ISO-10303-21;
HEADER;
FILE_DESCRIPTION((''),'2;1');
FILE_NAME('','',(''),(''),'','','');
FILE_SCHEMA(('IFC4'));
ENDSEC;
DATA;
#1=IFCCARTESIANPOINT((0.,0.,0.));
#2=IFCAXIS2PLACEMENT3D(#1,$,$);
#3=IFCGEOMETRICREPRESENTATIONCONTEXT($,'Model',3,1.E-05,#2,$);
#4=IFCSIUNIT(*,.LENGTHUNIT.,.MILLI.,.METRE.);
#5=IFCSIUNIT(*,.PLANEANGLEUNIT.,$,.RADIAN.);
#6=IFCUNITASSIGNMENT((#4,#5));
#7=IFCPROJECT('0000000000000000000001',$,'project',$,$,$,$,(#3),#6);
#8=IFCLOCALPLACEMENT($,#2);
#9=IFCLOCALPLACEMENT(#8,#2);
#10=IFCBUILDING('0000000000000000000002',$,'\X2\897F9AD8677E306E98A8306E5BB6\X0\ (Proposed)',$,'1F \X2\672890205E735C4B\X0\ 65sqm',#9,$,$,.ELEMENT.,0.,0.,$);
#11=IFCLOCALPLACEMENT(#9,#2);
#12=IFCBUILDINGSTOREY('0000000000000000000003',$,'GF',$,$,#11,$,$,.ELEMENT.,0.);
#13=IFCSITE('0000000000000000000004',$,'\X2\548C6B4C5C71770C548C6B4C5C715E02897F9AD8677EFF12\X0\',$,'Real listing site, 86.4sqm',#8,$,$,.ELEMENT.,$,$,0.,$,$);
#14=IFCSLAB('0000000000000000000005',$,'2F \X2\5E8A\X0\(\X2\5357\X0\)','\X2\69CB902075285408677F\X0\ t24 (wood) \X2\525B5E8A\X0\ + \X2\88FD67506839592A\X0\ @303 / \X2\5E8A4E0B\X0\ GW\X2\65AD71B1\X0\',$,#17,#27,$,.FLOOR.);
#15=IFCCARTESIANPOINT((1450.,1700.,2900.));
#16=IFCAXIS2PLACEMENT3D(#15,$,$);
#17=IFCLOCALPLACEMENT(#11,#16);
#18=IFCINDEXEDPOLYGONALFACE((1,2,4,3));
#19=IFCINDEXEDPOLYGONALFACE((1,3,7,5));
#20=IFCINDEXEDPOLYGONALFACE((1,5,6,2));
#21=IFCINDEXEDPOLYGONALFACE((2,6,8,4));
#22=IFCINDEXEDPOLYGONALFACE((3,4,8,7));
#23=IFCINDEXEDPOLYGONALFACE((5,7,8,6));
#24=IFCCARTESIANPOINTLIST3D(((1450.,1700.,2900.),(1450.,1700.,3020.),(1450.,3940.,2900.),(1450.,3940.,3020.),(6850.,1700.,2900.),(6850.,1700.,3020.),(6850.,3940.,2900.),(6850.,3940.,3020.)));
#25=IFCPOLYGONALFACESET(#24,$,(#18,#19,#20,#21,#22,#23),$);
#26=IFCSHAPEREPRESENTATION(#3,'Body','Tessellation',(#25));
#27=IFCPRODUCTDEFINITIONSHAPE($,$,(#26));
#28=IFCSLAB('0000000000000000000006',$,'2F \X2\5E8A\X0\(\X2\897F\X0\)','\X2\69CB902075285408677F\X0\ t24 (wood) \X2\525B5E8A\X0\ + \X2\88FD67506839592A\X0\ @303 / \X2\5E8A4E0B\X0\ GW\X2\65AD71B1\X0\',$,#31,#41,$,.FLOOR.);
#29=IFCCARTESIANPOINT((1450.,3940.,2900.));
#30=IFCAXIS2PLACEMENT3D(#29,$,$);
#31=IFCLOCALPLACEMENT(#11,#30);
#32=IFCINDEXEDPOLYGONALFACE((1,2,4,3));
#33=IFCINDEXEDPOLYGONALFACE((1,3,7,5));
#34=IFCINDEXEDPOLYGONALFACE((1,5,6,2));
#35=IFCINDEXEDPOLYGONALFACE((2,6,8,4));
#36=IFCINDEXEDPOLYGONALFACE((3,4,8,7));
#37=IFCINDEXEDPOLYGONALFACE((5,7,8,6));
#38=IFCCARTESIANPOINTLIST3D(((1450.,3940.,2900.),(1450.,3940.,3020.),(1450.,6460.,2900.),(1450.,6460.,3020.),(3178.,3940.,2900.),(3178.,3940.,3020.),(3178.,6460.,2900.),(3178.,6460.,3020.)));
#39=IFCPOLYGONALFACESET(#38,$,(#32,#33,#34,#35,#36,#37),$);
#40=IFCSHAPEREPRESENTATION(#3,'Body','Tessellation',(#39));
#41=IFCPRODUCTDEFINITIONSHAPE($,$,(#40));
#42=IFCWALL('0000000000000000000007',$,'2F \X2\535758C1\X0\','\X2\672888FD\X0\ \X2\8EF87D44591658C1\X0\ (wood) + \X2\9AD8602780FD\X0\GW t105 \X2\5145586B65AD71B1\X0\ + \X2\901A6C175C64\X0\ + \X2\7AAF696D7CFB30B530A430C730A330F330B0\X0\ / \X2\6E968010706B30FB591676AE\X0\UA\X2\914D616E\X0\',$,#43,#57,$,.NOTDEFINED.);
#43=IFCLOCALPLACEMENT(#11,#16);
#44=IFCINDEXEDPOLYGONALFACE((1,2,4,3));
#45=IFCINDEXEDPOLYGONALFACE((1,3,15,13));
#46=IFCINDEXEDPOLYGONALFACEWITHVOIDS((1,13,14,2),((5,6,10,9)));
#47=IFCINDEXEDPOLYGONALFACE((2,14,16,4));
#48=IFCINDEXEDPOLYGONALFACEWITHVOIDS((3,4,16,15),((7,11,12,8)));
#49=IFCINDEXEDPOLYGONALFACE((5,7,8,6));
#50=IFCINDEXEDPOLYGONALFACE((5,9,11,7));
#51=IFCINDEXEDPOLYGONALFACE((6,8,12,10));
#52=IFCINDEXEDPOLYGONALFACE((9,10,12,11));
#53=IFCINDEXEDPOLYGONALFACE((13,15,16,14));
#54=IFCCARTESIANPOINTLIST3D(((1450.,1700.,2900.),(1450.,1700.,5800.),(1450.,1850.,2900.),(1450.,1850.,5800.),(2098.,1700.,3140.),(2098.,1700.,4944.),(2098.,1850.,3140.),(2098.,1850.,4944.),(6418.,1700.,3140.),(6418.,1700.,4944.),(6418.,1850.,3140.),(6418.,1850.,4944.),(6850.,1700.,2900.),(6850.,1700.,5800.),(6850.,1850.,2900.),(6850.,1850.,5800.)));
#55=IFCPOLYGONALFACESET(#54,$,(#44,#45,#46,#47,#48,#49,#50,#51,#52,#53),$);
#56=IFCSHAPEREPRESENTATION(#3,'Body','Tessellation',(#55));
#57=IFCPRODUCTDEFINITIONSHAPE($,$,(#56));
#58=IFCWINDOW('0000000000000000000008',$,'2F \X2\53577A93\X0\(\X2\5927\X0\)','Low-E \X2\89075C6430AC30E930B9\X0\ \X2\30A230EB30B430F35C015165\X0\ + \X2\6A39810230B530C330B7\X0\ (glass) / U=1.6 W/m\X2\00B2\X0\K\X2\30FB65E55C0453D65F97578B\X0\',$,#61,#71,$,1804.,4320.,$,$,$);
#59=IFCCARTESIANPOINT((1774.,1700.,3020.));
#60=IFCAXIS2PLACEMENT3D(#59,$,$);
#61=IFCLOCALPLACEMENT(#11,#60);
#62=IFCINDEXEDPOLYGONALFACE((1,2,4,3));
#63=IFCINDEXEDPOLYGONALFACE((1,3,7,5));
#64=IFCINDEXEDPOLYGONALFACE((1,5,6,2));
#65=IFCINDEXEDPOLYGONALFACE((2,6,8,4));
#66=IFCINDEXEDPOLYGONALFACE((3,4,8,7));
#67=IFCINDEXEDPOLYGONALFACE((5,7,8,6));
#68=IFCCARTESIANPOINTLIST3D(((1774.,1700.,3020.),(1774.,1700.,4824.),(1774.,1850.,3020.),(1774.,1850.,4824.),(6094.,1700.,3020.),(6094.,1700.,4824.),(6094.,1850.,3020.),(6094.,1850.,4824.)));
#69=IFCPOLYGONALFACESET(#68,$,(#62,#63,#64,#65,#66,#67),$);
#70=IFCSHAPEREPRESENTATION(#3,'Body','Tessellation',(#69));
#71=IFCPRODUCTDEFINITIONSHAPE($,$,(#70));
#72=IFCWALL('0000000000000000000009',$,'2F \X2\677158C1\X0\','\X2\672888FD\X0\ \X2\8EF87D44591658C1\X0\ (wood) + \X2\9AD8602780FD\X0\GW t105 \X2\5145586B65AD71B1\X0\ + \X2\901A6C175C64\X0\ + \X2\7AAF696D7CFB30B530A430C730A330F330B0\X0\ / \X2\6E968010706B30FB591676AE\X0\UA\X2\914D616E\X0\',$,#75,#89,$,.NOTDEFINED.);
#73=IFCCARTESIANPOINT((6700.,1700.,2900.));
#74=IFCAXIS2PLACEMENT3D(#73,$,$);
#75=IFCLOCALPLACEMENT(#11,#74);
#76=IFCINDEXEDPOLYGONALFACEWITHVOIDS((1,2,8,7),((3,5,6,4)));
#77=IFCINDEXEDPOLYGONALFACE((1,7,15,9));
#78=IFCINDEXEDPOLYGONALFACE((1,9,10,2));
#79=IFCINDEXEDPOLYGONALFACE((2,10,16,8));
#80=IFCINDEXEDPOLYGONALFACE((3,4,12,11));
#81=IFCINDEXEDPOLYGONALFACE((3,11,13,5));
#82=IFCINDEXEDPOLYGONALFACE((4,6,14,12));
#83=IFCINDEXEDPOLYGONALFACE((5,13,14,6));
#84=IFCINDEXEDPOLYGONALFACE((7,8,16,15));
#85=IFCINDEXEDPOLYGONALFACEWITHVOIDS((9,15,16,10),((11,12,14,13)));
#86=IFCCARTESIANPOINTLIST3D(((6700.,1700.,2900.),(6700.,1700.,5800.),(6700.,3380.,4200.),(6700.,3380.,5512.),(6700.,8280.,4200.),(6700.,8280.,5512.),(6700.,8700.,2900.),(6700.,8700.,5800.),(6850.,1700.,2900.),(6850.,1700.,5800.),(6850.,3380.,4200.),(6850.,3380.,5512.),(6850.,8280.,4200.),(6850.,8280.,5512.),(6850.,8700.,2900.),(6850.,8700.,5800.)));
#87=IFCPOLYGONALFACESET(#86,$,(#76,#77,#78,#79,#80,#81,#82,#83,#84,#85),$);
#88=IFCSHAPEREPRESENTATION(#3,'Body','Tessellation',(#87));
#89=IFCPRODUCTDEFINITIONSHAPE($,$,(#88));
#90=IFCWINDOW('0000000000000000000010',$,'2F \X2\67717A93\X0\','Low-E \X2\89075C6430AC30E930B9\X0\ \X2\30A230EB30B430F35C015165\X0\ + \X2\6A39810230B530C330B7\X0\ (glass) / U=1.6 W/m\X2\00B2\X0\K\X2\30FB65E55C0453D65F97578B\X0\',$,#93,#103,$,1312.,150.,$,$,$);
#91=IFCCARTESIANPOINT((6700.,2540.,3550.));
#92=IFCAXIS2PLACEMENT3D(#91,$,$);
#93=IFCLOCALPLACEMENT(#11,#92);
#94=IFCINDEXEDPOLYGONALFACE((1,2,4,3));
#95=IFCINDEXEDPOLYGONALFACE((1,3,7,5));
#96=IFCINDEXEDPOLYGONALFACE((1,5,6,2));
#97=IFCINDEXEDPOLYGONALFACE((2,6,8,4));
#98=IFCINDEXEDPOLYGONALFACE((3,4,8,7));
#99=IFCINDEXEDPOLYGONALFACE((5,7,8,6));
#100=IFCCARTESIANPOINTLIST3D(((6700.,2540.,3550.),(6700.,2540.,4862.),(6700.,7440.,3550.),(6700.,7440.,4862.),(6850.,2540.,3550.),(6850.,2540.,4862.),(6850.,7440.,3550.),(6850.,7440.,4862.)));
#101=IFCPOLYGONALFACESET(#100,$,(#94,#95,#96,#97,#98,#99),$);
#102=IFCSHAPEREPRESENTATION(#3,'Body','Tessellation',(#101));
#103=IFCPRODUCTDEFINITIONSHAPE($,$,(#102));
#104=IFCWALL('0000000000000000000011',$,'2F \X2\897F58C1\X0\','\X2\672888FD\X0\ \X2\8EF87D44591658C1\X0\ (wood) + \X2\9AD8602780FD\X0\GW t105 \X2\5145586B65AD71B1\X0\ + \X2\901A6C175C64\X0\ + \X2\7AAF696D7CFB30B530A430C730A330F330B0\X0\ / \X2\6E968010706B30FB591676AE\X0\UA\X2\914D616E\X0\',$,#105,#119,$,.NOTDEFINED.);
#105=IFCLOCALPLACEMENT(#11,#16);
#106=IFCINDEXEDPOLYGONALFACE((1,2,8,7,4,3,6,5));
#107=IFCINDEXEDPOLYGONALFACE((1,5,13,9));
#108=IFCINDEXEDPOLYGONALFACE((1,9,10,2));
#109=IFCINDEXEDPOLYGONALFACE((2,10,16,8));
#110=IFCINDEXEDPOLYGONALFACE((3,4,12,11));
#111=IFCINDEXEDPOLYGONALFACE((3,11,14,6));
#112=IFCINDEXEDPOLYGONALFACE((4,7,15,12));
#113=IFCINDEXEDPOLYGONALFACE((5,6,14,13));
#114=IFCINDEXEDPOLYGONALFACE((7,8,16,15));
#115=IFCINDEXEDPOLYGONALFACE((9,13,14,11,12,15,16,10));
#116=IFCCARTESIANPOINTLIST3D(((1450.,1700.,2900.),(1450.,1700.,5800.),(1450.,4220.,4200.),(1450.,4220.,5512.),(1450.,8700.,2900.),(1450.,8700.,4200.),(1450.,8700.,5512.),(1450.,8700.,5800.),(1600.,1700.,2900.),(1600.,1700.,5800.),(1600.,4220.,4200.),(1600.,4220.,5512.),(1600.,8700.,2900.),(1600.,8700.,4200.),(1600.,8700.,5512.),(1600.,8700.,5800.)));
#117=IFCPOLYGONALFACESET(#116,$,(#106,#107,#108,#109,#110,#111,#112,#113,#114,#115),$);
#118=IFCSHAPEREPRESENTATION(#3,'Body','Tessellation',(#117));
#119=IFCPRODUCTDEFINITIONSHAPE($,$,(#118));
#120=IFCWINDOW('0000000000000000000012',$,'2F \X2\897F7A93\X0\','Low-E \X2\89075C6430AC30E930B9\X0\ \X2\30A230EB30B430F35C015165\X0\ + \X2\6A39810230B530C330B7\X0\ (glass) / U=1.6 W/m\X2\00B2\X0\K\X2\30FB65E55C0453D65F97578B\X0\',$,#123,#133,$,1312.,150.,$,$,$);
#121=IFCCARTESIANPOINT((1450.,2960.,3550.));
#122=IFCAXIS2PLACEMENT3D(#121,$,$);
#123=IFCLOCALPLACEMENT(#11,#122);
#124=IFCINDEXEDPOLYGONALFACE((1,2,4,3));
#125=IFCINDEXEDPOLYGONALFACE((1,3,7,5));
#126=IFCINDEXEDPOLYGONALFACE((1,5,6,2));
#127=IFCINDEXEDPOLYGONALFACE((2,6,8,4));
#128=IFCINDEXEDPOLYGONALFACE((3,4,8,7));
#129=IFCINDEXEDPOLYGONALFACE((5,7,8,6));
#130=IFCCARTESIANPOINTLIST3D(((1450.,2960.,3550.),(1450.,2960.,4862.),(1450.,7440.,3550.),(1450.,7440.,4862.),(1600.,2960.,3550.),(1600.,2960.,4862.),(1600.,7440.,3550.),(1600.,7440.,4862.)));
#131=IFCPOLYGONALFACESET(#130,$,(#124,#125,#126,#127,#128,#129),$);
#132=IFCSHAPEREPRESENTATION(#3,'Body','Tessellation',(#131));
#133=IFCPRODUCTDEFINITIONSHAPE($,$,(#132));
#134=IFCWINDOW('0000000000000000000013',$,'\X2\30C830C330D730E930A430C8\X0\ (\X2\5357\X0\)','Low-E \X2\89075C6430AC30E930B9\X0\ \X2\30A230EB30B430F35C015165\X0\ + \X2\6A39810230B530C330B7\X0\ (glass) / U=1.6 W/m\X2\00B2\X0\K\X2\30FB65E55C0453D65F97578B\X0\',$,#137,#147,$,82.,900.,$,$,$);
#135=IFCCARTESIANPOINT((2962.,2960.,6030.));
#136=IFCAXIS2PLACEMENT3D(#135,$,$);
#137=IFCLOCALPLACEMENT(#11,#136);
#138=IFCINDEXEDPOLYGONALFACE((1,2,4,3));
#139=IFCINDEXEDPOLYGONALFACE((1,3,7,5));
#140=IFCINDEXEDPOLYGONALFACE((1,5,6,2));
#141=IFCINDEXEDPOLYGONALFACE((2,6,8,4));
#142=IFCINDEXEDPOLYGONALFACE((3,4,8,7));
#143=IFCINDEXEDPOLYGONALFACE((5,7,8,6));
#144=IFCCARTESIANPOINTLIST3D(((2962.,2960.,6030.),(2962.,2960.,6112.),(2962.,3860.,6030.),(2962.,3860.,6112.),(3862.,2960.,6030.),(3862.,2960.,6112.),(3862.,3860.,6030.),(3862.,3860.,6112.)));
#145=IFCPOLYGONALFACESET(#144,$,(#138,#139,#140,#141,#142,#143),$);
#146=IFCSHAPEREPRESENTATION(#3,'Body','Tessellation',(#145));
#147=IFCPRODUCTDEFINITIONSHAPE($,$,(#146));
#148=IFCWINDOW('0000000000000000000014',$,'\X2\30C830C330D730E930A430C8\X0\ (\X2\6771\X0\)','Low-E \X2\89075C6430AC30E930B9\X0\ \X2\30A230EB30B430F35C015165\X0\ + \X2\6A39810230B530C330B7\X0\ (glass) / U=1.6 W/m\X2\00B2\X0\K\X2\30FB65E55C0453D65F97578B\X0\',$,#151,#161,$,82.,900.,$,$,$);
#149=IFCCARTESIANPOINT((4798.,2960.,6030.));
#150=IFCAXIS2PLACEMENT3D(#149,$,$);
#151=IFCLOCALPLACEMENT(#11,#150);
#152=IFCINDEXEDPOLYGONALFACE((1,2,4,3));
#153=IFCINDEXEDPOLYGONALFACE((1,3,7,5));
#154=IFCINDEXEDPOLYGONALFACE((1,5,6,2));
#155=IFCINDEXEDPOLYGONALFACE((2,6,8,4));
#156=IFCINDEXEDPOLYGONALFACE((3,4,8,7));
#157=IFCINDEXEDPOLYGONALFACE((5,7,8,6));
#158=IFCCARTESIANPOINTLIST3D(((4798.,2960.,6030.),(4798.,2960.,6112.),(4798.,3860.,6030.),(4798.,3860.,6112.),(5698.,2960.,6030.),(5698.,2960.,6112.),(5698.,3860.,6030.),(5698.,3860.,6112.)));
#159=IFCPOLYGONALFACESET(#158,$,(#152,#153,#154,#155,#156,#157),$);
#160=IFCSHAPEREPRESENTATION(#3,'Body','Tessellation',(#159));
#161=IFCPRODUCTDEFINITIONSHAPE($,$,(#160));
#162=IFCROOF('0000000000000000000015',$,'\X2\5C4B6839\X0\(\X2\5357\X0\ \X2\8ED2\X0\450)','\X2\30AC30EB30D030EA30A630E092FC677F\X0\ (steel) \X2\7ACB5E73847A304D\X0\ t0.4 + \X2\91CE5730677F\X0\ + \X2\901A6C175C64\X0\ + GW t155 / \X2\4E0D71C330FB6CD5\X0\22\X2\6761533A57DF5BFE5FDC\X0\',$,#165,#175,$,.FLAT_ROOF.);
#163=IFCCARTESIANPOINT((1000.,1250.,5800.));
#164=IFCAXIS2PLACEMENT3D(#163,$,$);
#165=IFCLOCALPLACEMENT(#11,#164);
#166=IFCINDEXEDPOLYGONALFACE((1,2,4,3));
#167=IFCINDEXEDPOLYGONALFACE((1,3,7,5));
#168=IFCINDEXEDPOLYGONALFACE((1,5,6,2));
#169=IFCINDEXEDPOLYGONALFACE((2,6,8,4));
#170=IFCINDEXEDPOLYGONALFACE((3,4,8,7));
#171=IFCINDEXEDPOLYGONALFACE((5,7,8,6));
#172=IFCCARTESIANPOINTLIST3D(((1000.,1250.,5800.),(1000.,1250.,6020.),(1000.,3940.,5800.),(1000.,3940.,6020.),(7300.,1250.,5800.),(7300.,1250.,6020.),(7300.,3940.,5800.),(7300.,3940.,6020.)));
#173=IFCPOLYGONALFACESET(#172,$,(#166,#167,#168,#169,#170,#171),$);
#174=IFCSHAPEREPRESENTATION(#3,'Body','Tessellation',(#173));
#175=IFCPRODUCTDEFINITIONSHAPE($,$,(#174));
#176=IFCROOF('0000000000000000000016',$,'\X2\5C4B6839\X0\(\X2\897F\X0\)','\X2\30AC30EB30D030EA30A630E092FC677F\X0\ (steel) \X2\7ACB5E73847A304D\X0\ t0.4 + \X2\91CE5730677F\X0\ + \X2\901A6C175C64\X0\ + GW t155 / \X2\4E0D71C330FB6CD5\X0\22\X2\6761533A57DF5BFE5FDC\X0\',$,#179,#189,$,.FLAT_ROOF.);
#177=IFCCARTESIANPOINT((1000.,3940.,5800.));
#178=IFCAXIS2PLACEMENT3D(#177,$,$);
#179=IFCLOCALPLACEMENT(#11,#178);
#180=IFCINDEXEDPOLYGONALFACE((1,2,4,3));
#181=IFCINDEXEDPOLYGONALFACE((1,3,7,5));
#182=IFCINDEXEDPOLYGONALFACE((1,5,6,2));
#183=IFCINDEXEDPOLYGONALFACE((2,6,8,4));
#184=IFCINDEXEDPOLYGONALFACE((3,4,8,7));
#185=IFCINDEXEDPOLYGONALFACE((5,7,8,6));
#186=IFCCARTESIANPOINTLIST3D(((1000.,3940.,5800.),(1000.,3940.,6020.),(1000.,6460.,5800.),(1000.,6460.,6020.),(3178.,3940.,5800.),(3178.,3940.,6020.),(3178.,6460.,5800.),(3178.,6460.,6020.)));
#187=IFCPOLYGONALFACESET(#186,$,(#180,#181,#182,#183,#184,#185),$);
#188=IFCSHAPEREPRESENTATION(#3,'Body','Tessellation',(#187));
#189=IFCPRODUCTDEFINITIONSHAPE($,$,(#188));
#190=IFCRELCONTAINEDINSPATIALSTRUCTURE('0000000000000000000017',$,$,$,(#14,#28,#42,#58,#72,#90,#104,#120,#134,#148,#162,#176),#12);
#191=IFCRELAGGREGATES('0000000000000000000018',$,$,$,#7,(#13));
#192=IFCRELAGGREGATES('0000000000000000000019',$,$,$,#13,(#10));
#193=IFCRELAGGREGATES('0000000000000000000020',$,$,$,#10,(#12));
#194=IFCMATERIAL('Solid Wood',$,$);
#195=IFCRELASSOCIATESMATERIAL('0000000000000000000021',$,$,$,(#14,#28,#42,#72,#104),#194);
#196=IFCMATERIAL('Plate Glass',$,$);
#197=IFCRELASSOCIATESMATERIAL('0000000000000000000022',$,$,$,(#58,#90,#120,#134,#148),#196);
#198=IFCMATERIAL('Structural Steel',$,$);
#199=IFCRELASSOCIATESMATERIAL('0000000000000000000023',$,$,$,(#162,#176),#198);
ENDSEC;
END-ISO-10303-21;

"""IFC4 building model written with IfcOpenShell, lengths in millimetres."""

from ifc_helpers import new_model, si_unit, frame, frame_2d, origin, place, context, project, spatial, rectangle, extrude, material, element, fill, save


model = new_model("IFC4")

# Units and contexts
model_context = context("Model", 3, precision=1e-05, world=origin())
ifc_project = project(units=[si_unit("LENGTHUNIT", "METRE", prefix="MILLI"), si_unit("PLANEANGLEUNIT", "RADIAN")], contexts=[model_context])

# Site, building, storey
site_placement = place(None, origin())
site = spatial("IfcSite", under=ifc_project, at=site_placement, Name="和歌山県和歌山市西高松２", ObjectType="Real listing site, 86.4sqm", CompositionType="ELEMENT", RefElevation=0.0)
building_placement = place(site_placement, origin())
building = spatial("IfcBuilding", under=site, at=building_placement, Name="西高松の風の家 (Proposed)", ObjectType="1F 木造平屋 65sqm", CompositionType="ELEMENT", ElevationOfRefHeight=0.0, ElevationOfTerrain=0.0)
storey_placement = place(building_placement, origin())
storey = spatial("IfcBuildingStorey", under=building, at=storey_placement, Name="GF", CompositionType="ELEMENT", Elevation=0.0)

# Slabs
ifc_material_1 = material(Name="Solid Wood")
slab_1_placement = place(storey_placement, frame((1450.0, 1700.0, 2900.0)))
element("IfcSlab", 1, at=slab_1_placement, inside=storey, material=ifc_material_1, Name="2F 床(南)", Description="構造用合板 t24 (wood) 剛床 + 製材根太 @303 / 床下 GW断熱", PredefinedType="FLOOR", context=model_context, shape_type="SweptSolid", body=[
    extrude(rectangle(XDim=5400.0, YDim=2240.0, at=frame_2d((2700.0, 1120.0))), frame((1450.0, 1700.0, 2900.0)), (0.0, 0.0, 1.0), 120.0),
])
slab_2_placement = place(storey_placement, frame((1450.0, 3940.0, 2900.0)))
element("IfcSlab", 2, at=slab_2_placement, inside=storey, material=ifc_material_1, Name="2F 床(西)", Description="構造用合板 t24 (wood) 剛床 + 製材根太 @303 / 床下 GW断熱", PredefinedType="FLOOR", context=model_context, shape_type="SweptSolid", body=[
    extrude(rectangle(XDim=1728.0, YDim=2520.0, at=frame_2d((864.0, 1260.0))), frame((1450.0, 3940.0, 2900.0)), (0.0, 0.0, 1.0), 120.0),
])

# Walls, openings, windows
wall_1_placement = place(storey_placement, frame((1450.0, 1700.0, 2900.0)))
wall_1 = element("IfcWall", 3, at=wall_1_placement, inside=storey, material=ifc_material_1, Name="2F 南壁", Description="木製 軸組外壁 (wood) + 高性能GW t105 充填断熱 + 通気層 + 窯業系サイディング / 準耐火・外皮UA配慮", PredefinedType="NOTDEFINED", context=model_context, shape_type="SweptSolid", body=[
    extrude(rectangle(XDim=5400.0, YDim=150.0, at=frame_2d((2700.0, 75.0))), frame((1450.0, 1700.0, 2900.0)), (0.0, 0.0, 1.0), 2900.0),
])
opening_1_placement = place(storey_placement, frame((1774.0, 1700.0, 3020.0)))
opening_1 = element("IfcOpeningElement", 4, at=opening_1_placement, cuts=wall_1, PredefinedType="NOTDEFINED", context=model_context, shape_type="SweptSolid", body=[
    extrude(rectangle(XDim=4320.0, YDim=150.0, at=frame_2d((2160.0, 75.0))), frame((1774.0, 1700.0, 3020.0)), (0.0, 0.0, 1.0), 1804.0),
])
ifc_material_2 = material(Name="Plate Glass")
window_1_placement = place(storey_placement, frame((1774.0, 1700.0, 3020.0)))
window_1 = element("IfcWindow", 5, at=window_1_placement, inside=storey, material=ifc_material_2, Name="2F 南窓(大)", Description="Low-E 複層ガラス アルゴン封入 + 樹脂サッシ (glass) / U=1.6 W/m²K・日射取得型", OverallHeight=1804.0, OverallWidth=4320.0, context=model_context, shape_type="SweptSolid", body=[
    extrude(rectangle(XDim=4320.0, YDim=150.0, at=frame_2d((2160.0, 75.0))), frame((1774.0, 1700.0, 3020.0)), (0.0, 0.0, 1.0), 1804.0),
])
fill(opening_1, window_1)
wall_2_placement = place(storey_placement, frame((6700.0, 1700.0, 2900.0)))
wall_2 = element("IfcWall", 6, at=wall_2_placement, inside=storey, material=ifc_material_1, Name="2F 東壁", Description="木製 軸組外壁 (wood) + 高性能GW t105 充填断熱 + 通気層 + 窯業系サイディング / 準耐火・外皮UA配慮", PredefinedType="NOTDEFINED", context=model_context, shape_type="SweptSolid", body=[
    extrude(rectangle(XDim=150.0, YDim=7000.0, at=frame_2d((75.0, 3500.0))), frame((6700.0, 1700.0, 2900.0)), (0.0, 0.0, 1.0), 2900.0),
])
opening_2_placement = place(storey_placement, frame((6700.0, 2540.0, 3550.0)))
opening_2 = element("IfcOpeningElement", 7, at=opening_2_placement, cuts=wall_2, PredefinedType="NOTDEFINED", context=model_context, shape_type="SweptSolid", body=[
    extrude(rectangle(XDim=150.0, YDim=4900.0, at=frame_2d((75.0, 2450.0))), frame((6700.0, 2540.0, 3550.0)), (0.0, 0.0, 1.0), 1312.0),
])
window_2_placement = place(storey_placement, frame((6700.0, 2540.0, 3550.0)))
window_2 = element("IfcWindow", 8, at=window_2_placement, inside=storey, material=ifc_material_2, Name="2F 東窓", Description="Low-E 複層ガラス アルゴン封入 + 樹脂サッシ (glass) / U=1.6 W/m²K・日射取得型", OverallHeight=1312.0, OverallWidth=150.0, context=model_context, shape_type="SweptSolid", body=[
    extrude(rectangle(XDim=150.0, YDim=4900.0, at=frame_2d((75.0, 2450.0))), frame((6700.0, 2540.0, 3550.0)), (0.0, 0.0, 1.0), 1312.0),
])
fill(opening_2, window_2)
wall_3_placement = place(storey_placement, frame((1450.0, 1700.0, 2900.0)))
wall_3 = element("IfcWall", 9, at=wall_3_placement, inside=storey, material=ifc_material_1, Name="2F 西壁", Description="木製 軸組外壁 (wood) + 高性能GW t105 充填断熱 + 通気層 + 窯業系サイディング / 準耐火・外皮UA配慮", PredefinedType="NOTDEFINED", context=model_context, shape_type="SweptSolid", body=[
    extrude(rectangle(XDim=150.0, YDim=7000.0, at=frame_2d((75.0, 3500.0))), frame((1450.0, 1700.0, 2900.0)), (0.0, 0.0, 1.0), 2900.0),
])
opening_3_placement = place(storey_placement, frame((1450.0, 2960.0, 3550.0)))
opening_3 = element("IfcOpeningElement", 10, at=opening_3_placement, cuts=wall_3, PredefinedType="NOTDEFINED", context=model_context, shape_type="SweptSolid", body=[
    extrude(rectangle(XDim=150.0, YDim=4480.0, at=frame_2d((75.0, 2240.0))), frame((1450.0, 2960.0, 3550.0)), (0.0, 0.0, 1.0), 1312.0),
])
window_3_placement = place(storey_placement, frame((1450.0, 2960.0, 3550.0)))
window_3 = element("IfcWindow", 11, at=window_3_placement, inside=storey, material=ifc_material_2, Name="2F 西窓", Description="Low-E 複層ガラス アルゴン封入 + 樹脂サッシ (glass) / U=1.6 W/m²K・日射取得型", OverallHeight=1312.0, OverallWidth=150.0, context=model_context, shape_type="SweptSolid", body=[
    extrude(rectangle(XDim=150.0, YDim=4480.0, at=frame_2d((75.0, 2240.0))), frame((1450.0, 2960.0, 3550.0)), (0.0, 0.0, 1.0), 1312.0),
])
fill(opening_3, window_3)

# Windows
window_4_placement = place(storey_placement, frame((2962.0, 2960.0, 6030.0)))
element("IfcWindow", 12, at=window_4_placement, inside=storey, material=ifc_material_2, Name="トップライト (南)", Description="Low-E 複層ガラス アルゴン封入 + 樹脂サッシ (glass) / U=1.6 W/m²K・日射取得型", OverallHeight=82.0, OverallWidth=900.0, context=model_context, shape_type="SweptSolid", body=[
    extrude(rectangle(XDim=900.0, YDim=900.0, at=frame_2d((450.0, 450.0))), frame((2962.0, 2960.0, 6030.0)), (0.0, 0.0, 1.0), 82.0),
])
window_5_placement = place(storey_placement, frame((4798.0, 2960.0, 6030.0)))
element("IfcWindow", 13, at=window_5_placement, inside=storey, material=ifc_material_2, Name="トップライト (東)", Description="Low-E 複層ガラス アルゴン封入 + 樹脂サッシ (glass) / U=1.6 W/m²K・日射取得型", OverallHeight=82.0, OverallWidth=900.0, context=model_context, shape_type="SweptSolid", body=[
    extrude(rectangle(XDim=900.0, YDim=900.0, at=frame_2d((450.0, 450.0))), frame((4798.0, 2960.0, 6030.0)), (0.0, 0.0, 1.0), 82.0),
])

# Roofs
ifc_material_3 = material(Name="Structural Steel")
roof_1_placement = place(storey_placement, frame((1000.0, 1250.0, 5800.0)))
element("IfcRoof", 14, at=roof_1_placement, inside=storey, material=ifc_material_3, Name="屋根(南 軒450)", Description="ガルバリウム鋼板 (steel) 立平葺き t0.4 + 野地板 + 通気層 + GW t155 / 不燃・法22条区域対応", PredefinedType="FLAT_ROOF", context=model_context, shape_type="SweptSolid", body=[
    extrude(rectangle(XDim=6300.0, YDim=2690.0, at=frame_2d((3150.0, 1345.0))), frame((1000.0, 1250.0, 5800.0)), (0.0, 0.0, 1.0), 220.0),
])
roof_2_placement = place(storey_placement, frame((1000.0, 3940.0, 5800.0)))
element("IfcRoof", 15, at=roof_2_placement, inside=storey, material=ifc_material_3, Name="屋根(西)", Description="ガルバリウム鋼板 (steel) 立平葺き t0.4 + 野地板 + 通気層 + GW t155 / 不燃・法22条区域対応", PredefinedType="FLAT_ROOF", context=model_context, shape_type="SweptSolid", body=[
    extrude(rectangle(XDim=2178.0, YDim=2520.0, at=frame_2d((1089.0, 1260.0))), frame((1000.0, 3940.0, 5800.0)), (0.0, 0.0, 1.0), 220.0),
])

save(model, "model.ifc")
